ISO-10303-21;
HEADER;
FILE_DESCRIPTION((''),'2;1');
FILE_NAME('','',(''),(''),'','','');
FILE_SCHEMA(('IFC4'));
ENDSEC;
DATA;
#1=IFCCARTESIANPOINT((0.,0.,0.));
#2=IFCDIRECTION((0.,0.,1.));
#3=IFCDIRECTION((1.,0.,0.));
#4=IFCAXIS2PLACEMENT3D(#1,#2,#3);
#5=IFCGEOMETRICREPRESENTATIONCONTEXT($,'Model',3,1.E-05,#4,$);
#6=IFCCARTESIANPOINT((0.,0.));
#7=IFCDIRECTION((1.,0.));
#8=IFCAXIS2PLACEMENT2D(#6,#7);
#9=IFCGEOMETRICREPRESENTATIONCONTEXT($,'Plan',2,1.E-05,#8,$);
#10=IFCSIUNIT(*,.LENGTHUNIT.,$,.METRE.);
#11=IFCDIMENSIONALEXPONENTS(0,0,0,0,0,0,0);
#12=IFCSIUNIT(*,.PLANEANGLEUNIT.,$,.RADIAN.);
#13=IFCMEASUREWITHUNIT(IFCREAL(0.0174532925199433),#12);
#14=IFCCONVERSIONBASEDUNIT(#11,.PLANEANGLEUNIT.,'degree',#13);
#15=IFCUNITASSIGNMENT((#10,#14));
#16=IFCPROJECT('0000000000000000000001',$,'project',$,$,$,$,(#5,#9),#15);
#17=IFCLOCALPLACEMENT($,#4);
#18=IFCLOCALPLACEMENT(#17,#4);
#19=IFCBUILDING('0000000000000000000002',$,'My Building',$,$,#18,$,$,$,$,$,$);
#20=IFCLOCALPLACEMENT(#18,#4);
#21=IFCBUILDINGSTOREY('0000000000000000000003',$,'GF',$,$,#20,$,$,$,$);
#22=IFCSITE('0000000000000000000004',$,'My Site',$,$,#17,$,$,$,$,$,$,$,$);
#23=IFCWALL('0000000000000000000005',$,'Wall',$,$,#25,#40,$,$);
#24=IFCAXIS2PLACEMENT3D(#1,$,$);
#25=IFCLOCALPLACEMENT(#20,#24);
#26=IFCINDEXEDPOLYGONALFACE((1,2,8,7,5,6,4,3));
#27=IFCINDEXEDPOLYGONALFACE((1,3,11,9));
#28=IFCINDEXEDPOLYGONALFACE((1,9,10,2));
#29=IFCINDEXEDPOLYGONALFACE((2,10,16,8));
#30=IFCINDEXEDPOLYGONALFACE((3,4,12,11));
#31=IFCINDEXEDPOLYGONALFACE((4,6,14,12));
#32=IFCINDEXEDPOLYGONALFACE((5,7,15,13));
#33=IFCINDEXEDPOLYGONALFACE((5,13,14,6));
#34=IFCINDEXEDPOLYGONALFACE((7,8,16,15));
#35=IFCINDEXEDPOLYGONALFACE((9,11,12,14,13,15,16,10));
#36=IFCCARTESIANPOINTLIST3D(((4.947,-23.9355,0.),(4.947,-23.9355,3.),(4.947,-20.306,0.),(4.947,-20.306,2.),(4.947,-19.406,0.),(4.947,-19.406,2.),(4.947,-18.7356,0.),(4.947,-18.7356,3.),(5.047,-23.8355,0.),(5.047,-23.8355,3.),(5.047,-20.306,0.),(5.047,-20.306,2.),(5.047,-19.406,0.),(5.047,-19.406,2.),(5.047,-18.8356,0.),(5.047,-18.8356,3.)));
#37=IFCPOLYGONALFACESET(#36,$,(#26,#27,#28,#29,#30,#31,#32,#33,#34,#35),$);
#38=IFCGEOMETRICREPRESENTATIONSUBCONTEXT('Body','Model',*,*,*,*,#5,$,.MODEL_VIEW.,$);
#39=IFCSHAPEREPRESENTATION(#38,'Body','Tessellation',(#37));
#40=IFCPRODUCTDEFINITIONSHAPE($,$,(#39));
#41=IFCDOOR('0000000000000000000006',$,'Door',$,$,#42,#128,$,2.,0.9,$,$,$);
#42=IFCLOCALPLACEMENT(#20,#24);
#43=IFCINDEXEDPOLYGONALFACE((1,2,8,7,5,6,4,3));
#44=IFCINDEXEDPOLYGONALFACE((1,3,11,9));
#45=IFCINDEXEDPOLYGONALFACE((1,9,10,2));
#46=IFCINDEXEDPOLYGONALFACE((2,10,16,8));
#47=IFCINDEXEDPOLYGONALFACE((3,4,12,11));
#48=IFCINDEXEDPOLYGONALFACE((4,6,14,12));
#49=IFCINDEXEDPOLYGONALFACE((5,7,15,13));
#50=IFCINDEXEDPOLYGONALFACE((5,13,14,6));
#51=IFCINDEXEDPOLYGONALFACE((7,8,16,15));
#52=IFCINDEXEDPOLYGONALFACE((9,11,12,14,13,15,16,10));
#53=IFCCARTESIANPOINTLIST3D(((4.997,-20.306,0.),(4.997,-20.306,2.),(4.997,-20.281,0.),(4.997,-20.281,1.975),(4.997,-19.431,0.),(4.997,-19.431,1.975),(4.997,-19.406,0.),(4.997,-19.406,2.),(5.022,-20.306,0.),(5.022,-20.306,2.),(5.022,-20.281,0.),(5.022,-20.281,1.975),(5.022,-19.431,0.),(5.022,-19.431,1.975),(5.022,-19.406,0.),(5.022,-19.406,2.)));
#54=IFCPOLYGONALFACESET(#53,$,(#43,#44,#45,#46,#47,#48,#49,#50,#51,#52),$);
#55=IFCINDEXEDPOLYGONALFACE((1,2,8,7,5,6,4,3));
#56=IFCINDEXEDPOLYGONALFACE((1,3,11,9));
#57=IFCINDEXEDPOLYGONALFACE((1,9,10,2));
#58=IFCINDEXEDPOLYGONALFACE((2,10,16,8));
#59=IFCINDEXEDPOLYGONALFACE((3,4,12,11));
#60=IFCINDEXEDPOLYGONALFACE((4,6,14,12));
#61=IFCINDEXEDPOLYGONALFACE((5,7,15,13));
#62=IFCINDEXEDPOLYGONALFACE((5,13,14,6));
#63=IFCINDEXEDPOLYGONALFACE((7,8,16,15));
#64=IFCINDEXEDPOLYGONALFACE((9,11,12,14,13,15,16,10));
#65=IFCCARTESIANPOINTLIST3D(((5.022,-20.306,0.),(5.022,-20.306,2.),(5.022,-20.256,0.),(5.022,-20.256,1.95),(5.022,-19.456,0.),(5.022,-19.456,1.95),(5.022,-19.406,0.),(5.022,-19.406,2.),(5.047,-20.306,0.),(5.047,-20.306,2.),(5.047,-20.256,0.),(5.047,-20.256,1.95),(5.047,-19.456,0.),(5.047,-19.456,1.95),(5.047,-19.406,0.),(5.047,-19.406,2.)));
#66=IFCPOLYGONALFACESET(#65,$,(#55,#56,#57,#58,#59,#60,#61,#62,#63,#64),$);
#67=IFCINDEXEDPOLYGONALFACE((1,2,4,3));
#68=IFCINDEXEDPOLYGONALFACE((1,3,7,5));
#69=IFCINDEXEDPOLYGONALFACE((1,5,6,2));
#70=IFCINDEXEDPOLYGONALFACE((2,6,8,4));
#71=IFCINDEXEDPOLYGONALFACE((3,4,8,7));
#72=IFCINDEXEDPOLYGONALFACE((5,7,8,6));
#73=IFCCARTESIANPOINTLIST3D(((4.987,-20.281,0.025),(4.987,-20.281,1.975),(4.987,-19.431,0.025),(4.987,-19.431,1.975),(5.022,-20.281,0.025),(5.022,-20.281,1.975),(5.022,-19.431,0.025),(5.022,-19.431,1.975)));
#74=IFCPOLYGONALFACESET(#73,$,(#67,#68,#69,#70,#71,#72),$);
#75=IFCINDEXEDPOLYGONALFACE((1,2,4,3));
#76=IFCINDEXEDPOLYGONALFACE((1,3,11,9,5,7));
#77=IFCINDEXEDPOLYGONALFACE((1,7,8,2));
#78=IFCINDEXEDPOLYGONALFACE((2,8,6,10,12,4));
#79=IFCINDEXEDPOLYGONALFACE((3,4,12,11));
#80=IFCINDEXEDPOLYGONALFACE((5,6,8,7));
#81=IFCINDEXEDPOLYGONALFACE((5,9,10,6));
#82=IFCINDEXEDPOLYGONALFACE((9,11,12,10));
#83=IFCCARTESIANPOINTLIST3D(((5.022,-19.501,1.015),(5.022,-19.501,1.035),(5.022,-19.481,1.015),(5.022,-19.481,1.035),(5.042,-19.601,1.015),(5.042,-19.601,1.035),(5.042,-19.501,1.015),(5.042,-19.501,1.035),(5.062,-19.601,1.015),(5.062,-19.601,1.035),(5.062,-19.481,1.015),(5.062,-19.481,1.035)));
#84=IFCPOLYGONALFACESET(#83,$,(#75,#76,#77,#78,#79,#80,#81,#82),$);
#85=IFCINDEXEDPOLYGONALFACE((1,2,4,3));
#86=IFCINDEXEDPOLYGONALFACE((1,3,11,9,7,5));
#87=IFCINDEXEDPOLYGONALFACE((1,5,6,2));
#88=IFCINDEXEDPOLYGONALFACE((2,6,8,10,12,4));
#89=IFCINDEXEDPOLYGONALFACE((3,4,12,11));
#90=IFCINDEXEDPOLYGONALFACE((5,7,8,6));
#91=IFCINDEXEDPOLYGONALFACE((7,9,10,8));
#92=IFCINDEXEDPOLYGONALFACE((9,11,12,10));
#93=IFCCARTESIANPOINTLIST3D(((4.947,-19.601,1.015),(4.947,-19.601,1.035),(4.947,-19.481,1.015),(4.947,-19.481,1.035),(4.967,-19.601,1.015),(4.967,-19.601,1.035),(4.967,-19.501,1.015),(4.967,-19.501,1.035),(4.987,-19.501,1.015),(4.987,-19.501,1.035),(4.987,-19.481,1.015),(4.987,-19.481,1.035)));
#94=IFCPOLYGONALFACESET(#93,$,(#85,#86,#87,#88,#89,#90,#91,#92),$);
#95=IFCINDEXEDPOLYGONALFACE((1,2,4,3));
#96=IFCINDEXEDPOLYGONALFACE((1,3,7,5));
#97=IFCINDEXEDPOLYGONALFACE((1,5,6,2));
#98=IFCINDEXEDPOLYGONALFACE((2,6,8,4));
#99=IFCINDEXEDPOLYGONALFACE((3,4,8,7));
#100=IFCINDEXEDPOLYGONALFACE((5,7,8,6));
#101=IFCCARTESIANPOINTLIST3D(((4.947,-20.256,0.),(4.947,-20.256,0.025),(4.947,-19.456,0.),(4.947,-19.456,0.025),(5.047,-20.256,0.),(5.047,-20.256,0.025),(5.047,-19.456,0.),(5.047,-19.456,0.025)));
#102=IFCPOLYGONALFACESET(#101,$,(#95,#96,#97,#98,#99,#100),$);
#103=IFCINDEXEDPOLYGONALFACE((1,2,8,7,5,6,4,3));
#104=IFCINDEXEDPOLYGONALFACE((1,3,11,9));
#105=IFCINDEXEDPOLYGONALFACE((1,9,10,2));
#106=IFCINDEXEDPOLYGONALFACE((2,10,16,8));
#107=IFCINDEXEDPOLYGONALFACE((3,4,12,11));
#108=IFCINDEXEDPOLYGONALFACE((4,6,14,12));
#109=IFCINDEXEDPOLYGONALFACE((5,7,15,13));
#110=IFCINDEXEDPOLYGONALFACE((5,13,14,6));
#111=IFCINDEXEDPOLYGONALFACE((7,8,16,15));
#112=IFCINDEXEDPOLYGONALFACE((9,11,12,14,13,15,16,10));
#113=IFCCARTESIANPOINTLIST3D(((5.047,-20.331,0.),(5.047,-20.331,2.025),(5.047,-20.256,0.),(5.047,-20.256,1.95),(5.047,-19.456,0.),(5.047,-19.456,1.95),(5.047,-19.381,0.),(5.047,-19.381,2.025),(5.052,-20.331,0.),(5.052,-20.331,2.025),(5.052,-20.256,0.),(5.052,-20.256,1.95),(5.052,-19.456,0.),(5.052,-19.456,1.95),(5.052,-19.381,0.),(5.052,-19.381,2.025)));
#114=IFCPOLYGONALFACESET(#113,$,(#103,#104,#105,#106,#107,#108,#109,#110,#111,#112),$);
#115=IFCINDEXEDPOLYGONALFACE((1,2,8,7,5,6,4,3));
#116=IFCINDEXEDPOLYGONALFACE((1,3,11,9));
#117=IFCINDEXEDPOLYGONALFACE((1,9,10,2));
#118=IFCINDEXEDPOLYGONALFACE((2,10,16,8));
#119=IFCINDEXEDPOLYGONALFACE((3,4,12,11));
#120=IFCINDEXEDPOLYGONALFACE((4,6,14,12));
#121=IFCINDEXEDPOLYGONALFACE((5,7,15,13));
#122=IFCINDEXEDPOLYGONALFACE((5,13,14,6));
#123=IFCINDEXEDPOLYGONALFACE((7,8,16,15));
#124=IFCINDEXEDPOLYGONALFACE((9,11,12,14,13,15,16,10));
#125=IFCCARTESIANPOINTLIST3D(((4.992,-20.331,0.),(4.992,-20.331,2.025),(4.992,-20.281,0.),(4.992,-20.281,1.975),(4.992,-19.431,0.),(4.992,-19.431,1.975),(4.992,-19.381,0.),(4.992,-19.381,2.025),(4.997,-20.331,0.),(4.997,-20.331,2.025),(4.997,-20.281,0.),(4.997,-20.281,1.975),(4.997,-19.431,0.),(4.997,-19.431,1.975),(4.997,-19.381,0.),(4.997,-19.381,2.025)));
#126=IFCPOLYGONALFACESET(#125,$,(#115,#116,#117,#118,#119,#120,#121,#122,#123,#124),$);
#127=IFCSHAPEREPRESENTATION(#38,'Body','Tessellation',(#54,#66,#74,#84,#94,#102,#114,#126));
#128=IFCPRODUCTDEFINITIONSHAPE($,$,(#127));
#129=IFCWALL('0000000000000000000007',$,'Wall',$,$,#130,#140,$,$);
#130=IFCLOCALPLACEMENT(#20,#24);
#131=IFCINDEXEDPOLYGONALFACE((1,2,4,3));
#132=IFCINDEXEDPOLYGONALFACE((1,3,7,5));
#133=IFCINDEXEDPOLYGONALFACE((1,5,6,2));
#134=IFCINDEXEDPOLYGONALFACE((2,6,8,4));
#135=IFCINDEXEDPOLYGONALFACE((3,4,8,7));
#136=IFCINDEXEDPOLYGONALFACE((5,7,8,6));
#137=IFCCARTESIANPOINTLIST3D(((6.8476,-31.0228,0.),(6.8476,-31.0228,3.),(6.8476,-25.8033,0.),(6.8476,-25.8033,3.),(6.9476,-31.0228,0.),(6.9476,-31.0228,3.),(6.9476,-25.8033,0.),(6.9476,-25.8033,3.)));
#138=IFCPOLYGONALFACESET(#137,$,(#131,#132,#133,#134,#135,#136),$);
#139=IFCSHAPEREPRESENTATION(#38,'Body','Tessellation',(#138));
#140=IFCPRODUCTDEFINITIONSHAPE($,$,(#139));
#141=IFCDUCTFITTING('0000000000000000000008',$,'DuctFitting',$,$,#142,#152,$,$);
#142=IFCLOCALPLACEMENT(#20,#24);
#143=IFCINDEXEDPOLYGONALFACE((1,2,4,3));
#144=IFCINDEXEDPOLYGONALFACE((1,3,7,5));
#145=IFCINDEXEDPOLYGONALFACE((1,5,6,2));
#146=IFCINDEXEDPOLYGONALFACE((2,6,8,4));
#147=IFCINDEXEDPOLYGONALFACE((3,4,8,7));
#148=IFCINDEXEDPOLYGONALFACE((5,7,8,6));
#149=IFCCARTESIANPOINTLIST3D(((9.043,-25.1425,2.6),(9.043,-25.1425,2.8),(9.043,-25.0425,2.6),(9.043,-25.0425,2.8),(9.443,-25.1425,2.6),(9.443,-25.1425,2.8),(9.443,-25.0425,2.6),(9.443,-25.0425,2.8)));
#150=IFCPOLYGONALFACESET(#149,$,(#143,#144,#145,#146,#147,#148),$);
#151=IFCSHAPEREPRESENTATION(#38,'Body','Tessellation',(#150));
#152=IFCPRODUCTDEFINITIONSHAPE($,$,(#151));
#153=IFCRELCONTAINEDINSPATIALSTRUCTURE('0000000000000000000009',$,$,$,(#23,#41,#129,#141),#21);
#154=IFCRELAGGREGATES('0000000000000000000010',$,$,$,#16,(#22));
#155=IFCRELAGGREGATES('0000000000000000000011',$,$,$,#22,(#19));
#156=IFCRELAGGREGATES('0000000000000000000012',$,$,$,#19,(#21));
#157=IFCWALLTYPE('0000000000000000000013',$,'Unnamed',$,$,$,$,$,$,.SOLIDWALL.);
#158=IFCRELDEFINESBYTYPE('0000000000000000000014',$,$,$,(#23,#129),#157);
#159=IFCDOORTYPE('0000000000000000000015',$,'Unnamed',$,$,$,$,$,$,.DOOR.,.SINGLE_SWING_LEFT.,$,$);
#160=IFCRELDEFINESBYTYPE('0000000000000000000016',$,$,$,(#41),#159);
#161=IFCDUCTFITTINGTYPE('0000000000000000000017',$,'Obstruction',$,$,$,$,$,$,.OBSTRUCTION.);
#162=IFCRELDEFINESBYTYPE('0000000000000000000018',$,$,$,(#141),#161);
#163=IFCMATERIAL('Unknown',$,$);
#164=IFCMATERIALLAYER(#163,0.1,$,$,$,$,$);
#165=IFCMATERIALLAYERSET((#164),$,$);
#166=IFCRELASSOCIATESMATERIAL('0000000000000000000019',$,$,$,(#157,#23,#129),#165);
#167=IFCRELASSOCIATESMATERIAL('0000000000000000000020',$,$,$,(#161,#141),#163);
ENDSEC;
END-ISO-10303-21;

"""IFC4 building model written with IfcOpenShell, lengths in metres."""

from ifc_helpers import new_model, entity, si_unit, converted_unit, frame, origin_with_axes, origin_2d_with_axis, place, context, subcontext, project, spatial, line, indexed_curve, rectangle, outline, extrude, shape, source, transform, mapped, material, layer, layer_set, layer_usage, material_profile, profile_set, profile_usage, type_object, type_shapes, element, fill, save


model = new_model("IFC4")

# Units and contexts
model_context = context("Model", 3, precision=1e-05, world=origin_with_axes())
plan_context = context("Plan", 2, precision=1e-05, world=origin_2d_with_axis())
body_context_1 = subcontext(model_context, "Body", "Model", "MODEL_VIEW")
body_context_2 = subcontext(plan_context, "Body", "Plan", "PLAN_VIEW")
ifc_project = project(units=[si_unit("LENGTHUNIT", "METRE"), converted_unit("PLANEANGLEUNIT", "degree", entity("IfcReal", 0.0174532925199433), si_unit("PLANEANGLEUNIT", "RADIAN"), dimensions=[0, 0, 0, 0, 0, 0, 0])], contexts=[model_context, plan_context])

# Site, building, storey
site_placement = place(None, origin_with_axes())
site = spatial("IfcSite", under=ifc_project, at=site_placement, Name="My Site")
building_placement = place(site_placement, origin_with_axes())
building = spatial("IfcBuilding", under=site, at=building_placement, Name="My Building")
storey_placement = place(building_placement, origin_with_axes())
storey = spatial("IfcBuildingStorey", under=building, at=storey_placement, Name="GF")

# Shared definitions
ifc_material = material(Name="Unknown")

# Shared definitions
ifc_layer_1 = layer(ifc_material, 0.1)
ifc_layer_set_1 = layer_set([ifc_layer_1])
wall_type = type_object("IfcWallType", Name="Unnamed", PredefinedType="SOLIDWALL", material=ifc_layer_set_1)

# Shared definitions
shared_shape_1 = source(origin_with_axes(), body_context_1, "Body", "SweptSolid", [
    extrude(outline(indexed_curve([(0.0, 0.0), (0.9, 0.0), (0.9, 2.0), (0.0, 2.0)], segments=[line(1, 2, 3, 4, 1)])), frame((0.0, -0.6, 0.0), z_axis=(0.0, -1.0, 0.0), x_axis=(1.0, 0.0, 0.0)), (0.0, 0.0, -1.0), 1.2),
])
door_type = type_object("IfcDoorType", Name="Unnamed", OperationType="SINGLE_SWING_LEFT", PredefinedType="DOOR")
shared_shape_2 = source(origin_with_axes(), body_context_1, "Body", "SweptSolid", [
    extrude(outline(indexed_curve([(0.0, 0.0), (0.0, 2.0), (0.9, 2.0), (0.9, 0.0), (0.875, 0.0), (0.875, 1.975), (0.025, 1.975), (0.025, 0.0)], segments=[line(1, 2, 3, 4, 5, 6, 7, 8, 1)])), frame((0.0, 0.025, 0.0), z_axis=(0.0, -1.0, 0.0), x_axis=(1.0, 0.0, 0.0)), (0.0, 0.0, -1.0), 0.025),
    extrude(outline(indexed_curve([(0.0, 0.0), (0.0, 2.0), (0.9, 2.0), (0.9, 0.0), (0.85, 0.0), (0.85, 1.95), (0.05, 1.95), (0.05, 0.0)], segments=[line(1, 2, 3, 4, 5, 6, 7, 8, 1)])), frame((0.0, 0.0, 0.0), z_axis=(0.0, -1.0, 0.0), x_axis=(1.0, 0.0, 0.0)), (0.0, 0.0, -1.0), 0.025),
    extrude(outline(indexed_curve([(0.0, 0.0), (0.85, 0.0), (0.85, 0.035), (0.0, 0.035)], segments=[line(1, 2, 3, 4, 1)])), frame((0.025, 0.025, 0.025), z_axis=(0.0, 0.0, 1.0), x_axis=(1.0, 0.0, 0.0)), (0.0, 0.0, 1.0), 1.95),
    extrude(outline(indexed_curve([(0.0, 0.0), (0.0, -0.04), (-0.12, -0.04), (-0.12, -0.02), (-0.02, -0.02), (-0.02, 0.0)], segments=[line(1, 2, 3, 4, 5, 6, 1)])), frame((0.825, 0.025, 1.015), z_axis=(0.0, 0.0, 1.0), x_axis=(1.0, 0.0, 0.0)), (0.0, 0.0, 1.0), 0.02),
    extrude(outline(indexed_curve([(0.0, 0.0), (0.0, 0.04), (-0.12, 0.04), (-0.12, 0.02), (-0.02, 0.02), (-0.02, 0.0)], segments=[line(1, 2, 3, 4, 5, 6, 1)])), frame((0.825, 0.06, 1.015), z_axis=(0.0, 0.0, 1.0), x_axis=(1.0, 0.0, 0.0)), (0.0, 0.0, 1.0), 0.02),
    extrude(outline(indexed_curve([(0.0, 0.0), (0.8, 0.0), (0.8, 0.1), (0.0, 0.1)], segments=[line(1, 2, 3, 4, 1)])), frame((0.05, 0.0, 0.0), z_axis=(0.0, 0.0, 1.0), x_axis=(1.0, 0.0, 0.0)), (0.0, 0.0, 1.0), 0.025),
    extrude(outline(indexed_curve([(0.0, 0.0), (0.0, 2.025), (0.95, 2.025), (0.95, 0.0), (0.875, 0.0), (0.875, 1.95), (0.075, 1.95), (0.075, 0.0)], segments=[line(1, 2, 3, 4, 5, 6, 7, 8, 1)])), frame((-0.025, -0.005, 0.0), z_axis=(0.0, -1.0, 0.0), x_axis=(1.0, 0.0, 0.0)), (0.0, 0.0, -1.0), 0.005),
    extrude(outline(indexed_curve([(0.0, 0.0), (0.0, 2.025), (0.95, 2.025), (0.95, 0.0), (0.9, 0.0), (0.9, 1.975), (0.05, 1.975), (0.05, 0.0)], segments=[line(1, 2, 3, 4, 5, 6, 7, 8, 1)])), frame((-0.025, 0.05, 0.0), z_axis=(0.0, -1.0, 0.0), x_axis=(1.0, 0.0, 0.0)), (0.0, 0.0, -1.0), 0.005),
])
shared_shape_3 = source(origin_with_axes(), body_context_2, "Body", "Curve2D", [
    entity("IfcIndexedPolyCurve", entity("IfcCartesianPointList2D", [[0.0, 0.0], [0.0, 0.05], [0.025, 0.05], [0.025, 0.025], [0.05, 0.025], [0.05, 0.0]]), [entity("IfcLineIndex", [1, 2, 3, 4, 5, 6, 1])]),
    entity("IfcIndexedPolyCurve", entity("IfcCartesianPointList2D", [[0.9, 0.0], [0.9, 0.05], [0.875, 0.05], [0.875, 0.025], [0.85, 0.025], [0.85, 0.0]]), [entity("IfcLineIndex", [1, 2, 3, 4, 5, 6, 1])]),
    entity("IfcTrimmedCurve", entity("IfcEllipse", entity("IfcAxis2Placement2D", entity("IfcCartesianPoint", [0.06, 0.05]), entity("IfcDirection", [1.0, 0.0])), 0.815, 0.85), [entity("IfcCartesianPoint", [0.875, 0.05])], [entity("IfcCartesianPoint", [0.06, 0.9])], True, "CARTESIAN"),
    entity("IfcIndexedPolyCurve", entity("IfcCartesianPointList2D", [[0.025, 0.05], [0.06, 0.05], [0.06, 0.9], [0.025, 0.9]]), [entity("IfcLineIndex", [1, 2, 3, 4, 1])]),
])
type_shapes(door_type, [shared_shape_2, shared_shape_3])

# Wall, opening, door
ifc_layer_usage_1 = layer_usage(ifc_layer_set_1, "AXIS2", "POSITIVE", 0.0)
wall_1_placement = place(storey_placement, frame((5.047, -23.8355, 0.0), z_axis=(0.0, 0.0, 1.0), x_axis=(0.0, 1.0, 0.0)))
wall_1 = element("IfcWall", 1, at=wall_1_placement, inside=storey, type_object=wall_type, material=ifc_layer_usage_1, Name="Wall", context=body_context_1, shape_type="SweptSolid", body=[
    extrude(outline(indexed_curve([(0.0, 0.0), (-0.1, 0.1), (5.1, 0.1), (5.0, 0.0)], segments=[line(1, 2, 3, 4, 1)])), origin_with_axes(), (0.0, 0.0, 1.0), 3.0),
])
opening_1_placement = place(wall_1_placement, frame((3.5295, 0.0, 0.0), z_axis=(0.0, 0.0, 1.0), x_axis=(1.0, 0.0, 0.0)))
opening_1 = element("IfcOpeningElement", 2, at=opening_1_placement, cuts=wall_1, PredefinedType="OPENING", context=body_context_1, shape_type="MappedRepresentation", body=[
    mapped(shared_shape_1, transform((0.0, 0.0, 0.0), x_axis=(1.0, 0.0, 0.0), y_axis=(0.0, 1.0, 0.0), z_axis=(0.0, 0.0, 1.0), scale=1.0)),
])
door_1_placement = place(opening_1_placement, frame((0.0, 0.0, 0.0), z_axis=(0.0, 0.0, 1.0), x_axis=(1.0, 0.0, 0.0)))
door_1 = element("IfcDoor", 3, at=door_1_placement, inside=storey, type_object=door_type, Name="Door", OverallHeight=2.0, OverallWidth=0.9, shapes=[
    shape(body_context_1, "Body", "MappedRepresentation", [mapped(shared_shape_2, transform((0.0, 0.0, 0.0), x_axis=(1.0, 0.0, 0.0), y_axis=(0.0, 1.0, 0.0), z_axis=(0.0, 0.0, 1.0), scale=1.0))]),
    shape(body_context_2, "Body", "MappedRepresentation", [mapped(shared_shape_3, transform((0.0, 0.0, 0.0), x_axis=(1.0, 0.0, 0.0), y_axis=(0.0, 1.0, 0.0), z_axis=(0.0, 0.0, 1.0), scale=1.0))]),
])
fill(opening_1, door_1)

# Wall
ifc_layer_usage_2 = layer_usage(ifc_layer_set_1, "AXIS2", "POSITIVE", 0.0)
wall_2_placement = place(storey_placement, frame((6.8476, -25.8033, 0.0), z_axis=(0.0, 0.0, 1.0), x_axis=(0.0, -1.0, 0.0)))
element("IfcWall", 4, at=wall_2_placement, inside=storey, type_object=wall_type, material=ifc_layer_usage_2, Name="Wall", context=body_context_1, shape_type="SweptSolid", body=[
    extrude(outline(indexed_curve([(0.0, 0.0), (0.0, 0.1), (5.2195, 0.1), (5.2195, 0.0)], segments=[line(1, 2, 3, 4, 1)])), origin_with_axes(), (0.0, 0.0, 1.0), 3.0),
])

# Duct fitting
ifc_material_profile = material_profile(ifc_material, rectangle(XDim=0.4, YDim=0.2))
ifc_profile_set = profile_set([ifc_material_profile])
ifc_profile_usage = profile_usage(ifc_profile_set, cardinal=5)
duct_fitting_type = type_object("IfcDuctFittingType", Name="Obstruction", PredefinedType="OBSTRUCTION", material=ifc_profile_set)
duct_fitting_placement = place(storey_placement, frame((9.243, -25.0425, 2.7), z_axis=(0.0, -1.0, 0.0), x_axis=(1.0, 0.0, 0.0)))
element("IfcDuctFitting", 5, at=duct_fitting_placement, inside=storey, type_object=duct_fitting_type, material=ifc_profile_usage, Name="DuctFitting", context=body_context_1, shape_type="SweptSolid", body=[
    extrude(rectangle(XDim=0.4, YDim=0.2), origin_with_axes(), (0.0, 0.0, 1.0), 0.1),
])

save(model, "model.ifc")
